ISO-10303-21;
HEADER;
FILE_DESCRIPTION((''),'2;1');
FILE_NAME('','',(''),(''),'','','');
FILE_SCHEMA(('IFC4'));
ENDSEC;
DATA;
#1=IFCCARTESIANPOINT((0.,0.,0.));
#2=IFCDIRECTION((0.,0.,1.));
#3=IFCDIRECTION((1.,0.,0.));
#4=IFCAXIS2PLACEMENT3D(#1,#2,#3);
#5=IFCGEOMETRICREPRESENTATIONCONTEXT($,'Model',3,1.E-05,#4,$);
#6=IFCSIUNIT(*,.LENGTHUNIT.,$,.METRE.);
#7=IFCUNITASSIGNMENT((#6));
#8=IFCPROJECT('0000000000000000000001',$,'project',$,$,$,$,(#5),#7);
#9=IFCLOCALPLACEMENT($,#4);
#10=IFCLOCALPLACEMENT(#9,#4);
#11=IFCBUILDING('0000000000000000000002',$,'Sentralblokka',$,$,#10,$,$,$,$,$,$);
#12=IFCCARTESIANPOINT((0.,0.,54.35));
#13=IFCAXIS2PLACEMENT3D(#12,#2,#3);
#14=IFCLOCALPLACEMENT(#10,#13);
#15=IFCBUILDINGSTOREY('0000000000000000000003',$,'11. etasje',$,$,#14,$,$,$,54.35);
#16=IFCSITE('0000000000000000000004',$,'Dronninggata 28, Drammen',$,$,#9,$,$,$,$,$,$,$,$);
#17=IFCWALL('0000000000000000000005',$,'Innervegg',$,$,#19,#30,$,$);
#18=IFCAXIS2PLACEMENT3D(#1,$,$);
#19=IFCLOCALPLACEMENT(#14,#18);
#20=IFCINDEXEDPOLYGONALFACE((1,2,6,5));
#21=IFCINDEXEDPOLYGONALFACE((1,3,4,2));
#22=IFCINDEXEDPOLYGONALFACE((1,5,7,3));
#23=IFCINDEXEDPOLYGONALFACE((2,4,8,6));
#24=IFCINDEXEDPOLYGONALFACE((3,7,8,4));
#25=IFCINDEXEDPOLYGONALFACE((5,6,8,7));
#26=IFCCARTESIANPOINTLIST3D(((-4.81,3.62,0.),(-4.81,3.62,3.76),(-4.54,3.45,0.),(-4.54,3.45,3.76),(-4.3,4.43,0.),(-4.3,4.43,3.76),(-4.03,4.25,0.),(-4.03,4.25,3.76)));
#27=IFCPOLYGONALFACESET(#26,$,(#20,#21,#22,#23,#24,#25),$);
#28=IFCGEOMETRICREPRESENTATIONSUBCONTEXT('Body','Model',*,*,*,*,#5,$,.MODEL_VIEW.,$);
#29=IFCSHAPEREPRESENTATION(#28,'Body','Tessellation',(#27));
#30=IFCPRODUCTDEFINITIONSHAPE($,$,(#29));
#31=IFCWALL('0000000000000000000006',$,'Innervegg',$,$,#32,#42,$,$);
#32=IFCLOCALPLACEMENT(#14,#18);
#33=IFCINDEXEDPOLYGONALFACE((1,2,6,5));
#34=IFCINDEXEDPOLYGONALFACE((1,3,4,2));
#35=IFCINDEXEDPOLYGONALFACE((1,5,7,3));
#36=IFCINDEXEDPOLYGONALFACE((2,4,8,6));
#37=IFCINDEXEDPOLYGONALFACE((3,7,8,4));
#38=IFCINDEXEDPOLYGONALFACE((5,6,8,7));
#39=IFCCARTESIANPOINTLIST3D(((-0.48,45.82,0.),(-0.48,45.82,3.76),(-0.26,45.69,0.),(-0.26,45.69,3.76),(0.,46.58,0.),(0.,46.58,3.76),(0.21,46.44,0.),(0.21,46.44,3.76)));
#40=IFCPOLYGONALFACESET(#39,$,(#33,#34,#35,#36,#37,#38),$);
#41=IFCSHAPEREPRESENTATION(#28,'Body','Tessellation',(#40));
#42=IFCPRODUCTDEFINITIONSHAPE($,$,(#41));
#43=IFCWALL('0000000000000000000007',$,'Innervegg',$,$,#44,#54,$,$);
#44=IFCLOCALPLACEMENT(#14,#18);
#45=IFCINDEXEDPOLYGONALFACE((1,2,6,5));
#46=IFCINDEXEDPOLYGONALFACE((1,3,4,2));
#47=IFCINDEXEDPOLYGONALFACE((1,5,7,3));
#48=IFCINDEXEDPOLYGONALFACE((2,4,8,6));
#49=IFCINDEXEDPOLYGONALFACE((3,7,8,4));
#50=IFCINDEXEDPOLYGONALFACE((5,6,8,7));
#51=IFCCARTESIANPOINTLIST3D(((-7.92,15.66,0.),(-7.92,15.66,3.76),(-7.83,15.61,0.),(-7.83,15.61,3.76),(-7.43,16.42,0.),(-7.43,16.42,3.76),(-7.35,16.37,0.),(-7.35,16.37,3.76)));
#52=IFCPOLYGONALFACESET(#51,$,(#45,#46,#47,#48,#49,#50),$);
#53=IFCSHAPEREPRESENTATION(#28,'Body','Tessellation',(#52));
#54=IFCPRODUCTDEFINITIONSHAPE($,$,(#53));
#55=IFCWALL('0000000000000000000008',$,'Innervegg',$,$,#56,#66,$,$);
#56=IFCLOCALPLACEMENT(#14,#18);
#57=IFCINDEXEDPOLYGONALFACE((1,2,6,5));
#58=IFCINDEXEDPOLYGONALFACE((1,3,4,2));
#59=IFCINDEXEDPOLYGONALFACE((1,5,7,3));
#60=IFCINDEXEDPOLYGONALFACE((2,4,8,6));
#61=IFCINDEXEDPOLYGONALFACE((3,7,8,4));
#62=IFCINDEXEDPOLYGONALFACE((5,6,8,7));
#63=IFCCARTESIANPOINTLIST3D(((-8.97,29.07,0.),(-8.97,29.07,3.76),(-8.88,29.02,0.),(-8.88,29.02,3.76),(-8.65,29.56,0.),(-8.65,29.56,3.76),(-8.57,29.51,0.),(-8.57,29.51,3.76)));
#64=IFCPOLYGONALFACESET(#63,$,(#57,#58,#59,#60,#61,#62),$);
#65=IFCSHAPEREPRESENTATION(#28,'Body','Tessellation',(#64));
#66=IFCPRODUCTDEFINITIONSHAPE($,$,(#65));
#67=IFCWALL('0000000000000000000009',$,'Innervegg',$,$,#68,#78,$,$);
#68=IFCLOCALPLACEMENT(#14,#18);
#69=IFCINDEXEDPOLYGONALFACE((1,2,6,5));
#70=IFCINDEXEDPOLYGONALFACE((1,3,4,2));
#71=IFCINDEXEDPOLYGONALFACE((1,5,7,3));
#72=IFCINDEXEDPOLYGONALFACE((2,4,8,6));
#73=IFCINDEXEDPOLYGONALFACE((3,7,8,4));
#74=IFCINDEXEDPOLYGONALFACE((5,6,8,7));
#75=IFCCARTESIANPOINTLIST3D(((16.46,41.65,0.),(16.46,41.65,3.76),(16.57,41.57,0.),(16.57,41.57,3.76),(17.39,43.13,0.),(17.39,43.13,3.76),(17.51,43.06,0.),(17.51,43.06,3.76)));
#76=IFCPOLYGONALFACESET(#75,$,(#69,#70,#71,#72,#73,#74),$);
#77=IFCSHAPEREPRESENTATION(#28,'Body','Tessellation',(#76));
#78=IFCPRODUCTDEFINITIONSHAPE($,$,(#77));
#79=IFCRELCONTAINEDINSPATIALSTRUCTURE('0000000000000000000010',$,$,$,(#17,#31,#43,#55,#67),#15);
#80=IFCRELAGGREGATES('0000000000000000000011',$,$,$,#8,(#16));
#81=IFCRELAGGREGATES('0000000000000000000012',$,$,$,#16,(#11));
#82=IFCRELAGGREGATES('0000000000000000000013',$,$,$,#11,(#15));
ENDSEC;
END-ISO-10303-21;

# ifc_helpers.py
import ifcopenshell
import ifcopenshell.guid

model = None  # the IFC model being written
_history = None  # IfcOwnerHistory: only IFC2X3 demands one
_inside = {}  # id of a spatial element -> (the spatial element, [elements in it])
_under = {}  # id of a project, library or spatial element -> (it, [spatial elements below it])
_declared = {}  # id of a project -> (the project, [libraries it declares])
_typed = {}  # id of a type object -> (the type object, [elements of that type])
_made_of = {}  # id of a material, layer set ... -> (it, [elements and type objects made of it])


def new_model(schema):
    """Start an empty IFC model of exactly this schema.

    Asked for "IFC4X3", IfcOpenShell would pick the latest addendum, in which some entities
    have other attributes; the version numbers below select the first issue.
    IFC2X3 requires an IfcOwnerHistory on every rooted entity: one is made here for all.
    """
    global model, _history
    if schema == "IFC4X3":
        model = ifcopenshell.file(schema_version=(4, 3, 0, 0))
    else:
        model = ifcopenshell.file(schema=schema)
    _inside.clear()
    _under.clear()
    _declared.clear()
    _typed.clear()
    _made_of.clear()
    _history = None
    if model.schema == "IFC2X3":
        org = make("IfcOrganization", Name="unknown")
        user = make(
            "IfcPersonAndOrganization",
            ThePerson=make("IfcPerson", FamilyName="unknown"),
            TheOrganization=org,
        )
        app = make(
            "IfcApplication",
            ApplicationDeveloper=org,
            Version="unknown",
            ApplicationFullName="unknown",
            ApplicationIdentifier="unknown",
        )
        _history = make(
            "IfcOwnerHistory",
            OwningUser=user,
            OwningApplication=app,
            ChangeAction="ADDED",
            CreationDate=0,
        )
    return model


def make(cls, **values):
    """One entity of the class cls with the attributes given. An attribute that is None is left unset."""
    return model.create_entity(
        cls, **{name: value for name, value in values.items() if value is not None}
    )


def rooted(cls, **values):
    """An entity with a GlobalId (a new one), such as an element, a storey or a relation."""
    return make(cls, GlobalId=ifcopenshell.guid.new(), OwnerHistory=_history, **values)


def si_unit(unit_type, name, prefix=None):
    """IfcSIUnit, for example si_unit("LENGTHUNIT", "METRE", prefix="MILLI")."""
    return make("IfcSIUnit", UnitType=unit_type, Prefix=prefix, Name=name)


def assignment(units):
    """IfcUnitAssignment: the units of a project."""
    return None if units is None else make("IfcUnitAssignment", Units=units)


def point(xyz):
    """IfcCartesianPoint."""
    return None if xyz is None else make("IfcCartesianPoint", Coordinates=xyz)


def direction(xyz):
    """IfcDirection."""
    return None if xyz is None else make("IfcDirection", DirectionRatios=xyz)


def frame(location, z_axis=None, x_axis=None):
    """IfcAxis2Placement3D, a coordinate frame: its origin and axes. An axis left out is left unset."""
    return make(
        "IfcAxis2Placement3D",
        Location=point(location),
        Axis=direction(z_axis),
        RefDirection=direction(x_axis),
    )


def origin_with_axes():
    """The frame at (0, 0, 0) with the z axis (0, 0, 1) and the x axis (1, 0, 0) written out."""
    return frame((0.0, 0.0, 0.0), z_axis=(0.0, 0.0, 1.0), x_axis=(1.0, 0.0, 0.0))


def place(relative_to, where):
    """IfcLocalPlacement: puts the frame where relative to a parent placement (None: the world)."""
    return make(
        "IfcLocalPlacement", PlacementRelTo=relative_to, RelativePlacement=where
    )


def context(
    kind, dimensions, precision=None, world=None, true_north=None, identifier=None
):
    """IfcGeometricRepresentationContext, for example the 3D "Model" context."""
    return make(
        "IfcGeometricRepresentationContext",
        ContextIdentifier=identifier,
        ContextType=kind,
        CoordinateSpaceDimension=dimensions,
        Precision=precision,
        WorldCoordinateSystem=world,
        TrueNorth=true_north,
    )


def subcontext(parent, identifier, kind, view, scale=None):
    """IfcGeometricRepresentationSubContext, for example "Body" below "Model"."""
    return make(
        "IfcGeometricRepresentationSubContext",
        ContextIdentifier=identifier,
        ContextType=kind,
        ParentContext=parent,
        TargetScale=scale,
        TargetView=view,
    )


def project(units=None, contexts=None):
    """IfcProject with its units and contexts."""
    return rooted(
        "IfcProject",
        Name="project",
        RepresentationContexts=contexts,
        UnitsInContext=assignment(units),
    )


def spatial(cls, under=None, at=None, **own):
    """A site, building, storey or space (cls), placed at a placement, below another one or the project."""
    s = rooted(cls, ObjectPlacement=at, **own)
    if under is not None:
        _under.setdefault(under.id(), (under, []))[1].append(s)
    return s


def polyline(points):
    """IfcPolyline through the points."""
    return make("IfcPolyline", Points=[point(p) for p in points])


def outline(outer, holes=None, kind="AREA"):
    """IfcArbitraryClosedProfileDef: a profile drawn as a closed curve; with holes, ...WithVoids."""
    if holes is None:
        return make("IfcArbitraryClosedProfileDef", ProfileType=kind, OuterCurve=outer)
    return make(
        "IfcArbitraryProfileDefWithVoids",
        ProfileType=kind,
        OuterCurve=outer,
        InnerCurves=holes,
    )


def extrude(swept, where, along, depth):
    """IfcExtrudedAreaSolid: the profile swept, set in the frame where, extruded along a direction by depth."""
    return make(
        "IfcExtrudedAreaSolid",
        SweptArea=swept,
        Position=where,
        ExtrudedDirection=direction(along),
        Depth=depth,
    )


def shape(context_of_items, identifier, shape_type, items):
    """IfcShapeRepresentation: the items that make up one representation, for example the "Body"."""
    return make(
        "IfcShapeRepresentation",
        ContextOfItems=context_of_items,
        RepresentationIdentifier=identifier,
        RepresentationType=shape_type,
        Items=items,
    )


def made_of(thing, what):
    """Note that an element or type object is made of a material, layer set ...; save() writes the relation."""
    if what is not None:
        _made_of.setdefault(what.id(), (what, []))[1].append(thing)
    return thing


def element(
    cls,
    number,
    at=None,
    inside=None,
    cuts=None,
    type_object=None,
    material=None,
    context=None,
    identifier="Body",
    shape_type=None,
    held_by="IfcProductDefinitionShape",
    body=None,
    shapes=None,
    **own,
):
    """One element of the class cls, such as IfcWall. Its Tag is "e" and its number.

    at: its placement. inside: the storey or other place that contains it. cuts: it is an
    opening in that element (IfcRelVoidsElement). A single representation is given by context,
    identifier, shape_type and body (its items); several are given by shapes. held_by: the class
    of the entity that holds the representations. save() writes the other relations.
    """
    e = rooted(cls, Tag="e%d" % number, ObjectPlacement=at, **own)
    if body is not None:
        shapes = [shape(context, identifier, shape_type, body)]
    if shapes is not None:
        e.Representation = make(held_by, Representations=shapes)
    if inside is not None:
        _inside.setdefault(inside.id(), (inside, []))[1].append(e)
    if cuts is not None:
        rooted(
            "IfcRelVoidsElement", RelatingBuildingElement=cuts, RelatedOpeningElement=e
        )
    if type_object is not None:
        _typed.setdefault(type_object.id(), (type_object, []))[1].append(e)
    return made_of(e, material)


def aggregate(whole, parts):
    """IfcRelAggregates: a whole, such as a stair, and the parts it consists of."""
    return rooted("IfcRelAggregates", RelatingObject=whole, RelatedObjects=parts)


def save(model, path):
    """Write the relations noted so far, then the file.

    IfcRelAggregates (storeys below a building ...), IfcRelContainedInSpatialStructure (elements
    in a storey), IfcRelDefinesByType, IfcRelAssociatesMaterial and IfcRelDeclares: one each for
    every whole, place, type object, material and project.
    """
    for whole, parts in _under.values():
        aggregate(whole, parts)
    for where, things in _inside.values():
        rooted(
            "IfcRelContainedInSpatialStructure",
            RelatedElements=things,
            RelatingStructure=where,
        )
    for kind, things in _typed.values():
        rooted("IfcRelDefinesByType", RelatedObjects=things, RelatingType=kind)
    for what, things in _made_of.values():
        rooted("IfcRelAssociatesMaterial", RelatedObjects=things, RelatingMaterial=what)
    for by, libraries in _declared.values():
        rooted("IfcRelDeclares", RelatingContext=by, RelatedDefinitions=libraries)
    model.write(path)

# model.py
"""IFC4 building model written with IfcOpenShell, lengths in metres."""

from ifc_helpers import new_model, si_unit, frame, origin_with_axes, place, context, subcontext, project, spatial, polyline, outline, extrude, element, save


model = new_model("IFC4")

# Units and contexts
model_context = context("Model", 3, precision=1e-05, world=origin_with_axes())
body_context = subcontext(model_context, "Body", "Model", "MODEL_VIEW")
ifc_project = project(units=[si_unit("LENGTHUNIT", "METRE")], contexts=[model_context])

# Site, building, storey
site_placement = place(None, origin_with_axes())
site = spatial("IfcSite", under=ifc_project, at=site_placement, Name="Dronninggata 28, Drammen")
building_placement = place(site_placement, origin_with_axes())
building = spatial("IfcBuilding", under=site, at=building_placement, Name="Sentralblokka")
storey_placement = place(building_placement, frame((0.0, 0.0, 54.35), z_axis=(0.0, 0.0, 1.0), x_axis=(1.0, 0.0, 0.0)))
storey = spatial("IfcBuildingStorey", under=building, at=storey_placement, Name="11. etasje", Elevation=54.35)

# Walls
wall_1_placement = place(storey_placement, frame((0.0, 0.0, -54.35), z_axis=(0.0, 0.0, 1.0), x_axis=(1.0, 0.0, 0.0)))
element("IfcWall", 1, at=wall_1_placement, inside=storey, Name="Innervegg", context=body_context, shape_type="SweptSolid", body=[
    extrude(outline(polyline([(-4.03, 4.25), (-4.54, 3.45), (-4.81, 3.62), (-4.3, 4.43), (-4.03, 4.25)])), frame((0.0, 0.0, 54.35)), (0.0, 0.0, 1.0), 3.76),
])
wall_2_placement = place(storey_placement, frame((0.0, 0.0, -54.35), z_axis=(0.0, 0.0, 1.0), x_axis=(1.0, 0.0, 0.0)))
element("IfcWall", 2, at=wall_2_placement, inside=storey, Name="Innervegg", context=body_context, shape_type="SweptSolid", body=[
    extrude(outline(polyline([(0.21, 46.44), (-0.26, 45.69), (-0.48, 45.82), (0.0, 46.58), (0.21, 46.44)])), frame((0.0, 0.0, 54.35)), (0.0, 0.0, 1.0), 3.76),
])
wall_3_placement = place(storey_placement, frame((0.0, 0.0, -54.35), z_axis=(0.0, 0.0, 1.0), x_axis=(1.0, 0.0, 0.0)))
element("IfcWall", 3, at=wall_3_placement, inside=storey, Name="Innervegg", context=body_context, shape_type="SweptSolid", body=[
    extrude(outline(polyline([(-7.35, 16.37), (-7.83, 15.61), (-7.92, 15.66), (-7.43, 16.42), (-7.35, 16.37)])), frame((0.0, 0.0, 54.35)), (0.0, 0.0, 1.0), 3.76),
])
wall_4_placement = place(storey_placement, frame((0.0, 0.0, -54.35), z_axis=(0.0, 0.0, 1.0), x_axis=(1.0, 0.0, 0.0)))
element("IfcWall", 4, at=wall_4_placement, inside=storey, Name="Innervegg", context=body_context, shape_type="SweptSolid", body=[
    extrude(outline(polyline([(-8.57, 29.51), (-8.88, 29.02), (-8.97, 29.07), (-8.65, 29.56), (-8.57, 29.51)])), frame((0.0, 0.0, 54.35)), (0.0, 0.0, 1.0), 3.76),
])
wall_5_placement = place(storey_placement, frame((0.0, 0.0, -54.35), z_axis=(0.0, 0.0, 1.0), x_axis=(1.0, 0.0, 0.0)))
element("IfcWall", 5, at=wall_5_placement, inside=storey, Name="Innervegg", context=body_context, shape_type="SweptSolid", body=[
    extrude(outline(polyline([(17.51, 43.06), (16.57, 41.57), (16.46, 41.65), (17.39, 43.13), (17.51, 43.06)])), frame((0.0, 0.0, 54.35)), (0.0, 0.0, 1.0), 3.76),
])

save(model, "model.ifc")
